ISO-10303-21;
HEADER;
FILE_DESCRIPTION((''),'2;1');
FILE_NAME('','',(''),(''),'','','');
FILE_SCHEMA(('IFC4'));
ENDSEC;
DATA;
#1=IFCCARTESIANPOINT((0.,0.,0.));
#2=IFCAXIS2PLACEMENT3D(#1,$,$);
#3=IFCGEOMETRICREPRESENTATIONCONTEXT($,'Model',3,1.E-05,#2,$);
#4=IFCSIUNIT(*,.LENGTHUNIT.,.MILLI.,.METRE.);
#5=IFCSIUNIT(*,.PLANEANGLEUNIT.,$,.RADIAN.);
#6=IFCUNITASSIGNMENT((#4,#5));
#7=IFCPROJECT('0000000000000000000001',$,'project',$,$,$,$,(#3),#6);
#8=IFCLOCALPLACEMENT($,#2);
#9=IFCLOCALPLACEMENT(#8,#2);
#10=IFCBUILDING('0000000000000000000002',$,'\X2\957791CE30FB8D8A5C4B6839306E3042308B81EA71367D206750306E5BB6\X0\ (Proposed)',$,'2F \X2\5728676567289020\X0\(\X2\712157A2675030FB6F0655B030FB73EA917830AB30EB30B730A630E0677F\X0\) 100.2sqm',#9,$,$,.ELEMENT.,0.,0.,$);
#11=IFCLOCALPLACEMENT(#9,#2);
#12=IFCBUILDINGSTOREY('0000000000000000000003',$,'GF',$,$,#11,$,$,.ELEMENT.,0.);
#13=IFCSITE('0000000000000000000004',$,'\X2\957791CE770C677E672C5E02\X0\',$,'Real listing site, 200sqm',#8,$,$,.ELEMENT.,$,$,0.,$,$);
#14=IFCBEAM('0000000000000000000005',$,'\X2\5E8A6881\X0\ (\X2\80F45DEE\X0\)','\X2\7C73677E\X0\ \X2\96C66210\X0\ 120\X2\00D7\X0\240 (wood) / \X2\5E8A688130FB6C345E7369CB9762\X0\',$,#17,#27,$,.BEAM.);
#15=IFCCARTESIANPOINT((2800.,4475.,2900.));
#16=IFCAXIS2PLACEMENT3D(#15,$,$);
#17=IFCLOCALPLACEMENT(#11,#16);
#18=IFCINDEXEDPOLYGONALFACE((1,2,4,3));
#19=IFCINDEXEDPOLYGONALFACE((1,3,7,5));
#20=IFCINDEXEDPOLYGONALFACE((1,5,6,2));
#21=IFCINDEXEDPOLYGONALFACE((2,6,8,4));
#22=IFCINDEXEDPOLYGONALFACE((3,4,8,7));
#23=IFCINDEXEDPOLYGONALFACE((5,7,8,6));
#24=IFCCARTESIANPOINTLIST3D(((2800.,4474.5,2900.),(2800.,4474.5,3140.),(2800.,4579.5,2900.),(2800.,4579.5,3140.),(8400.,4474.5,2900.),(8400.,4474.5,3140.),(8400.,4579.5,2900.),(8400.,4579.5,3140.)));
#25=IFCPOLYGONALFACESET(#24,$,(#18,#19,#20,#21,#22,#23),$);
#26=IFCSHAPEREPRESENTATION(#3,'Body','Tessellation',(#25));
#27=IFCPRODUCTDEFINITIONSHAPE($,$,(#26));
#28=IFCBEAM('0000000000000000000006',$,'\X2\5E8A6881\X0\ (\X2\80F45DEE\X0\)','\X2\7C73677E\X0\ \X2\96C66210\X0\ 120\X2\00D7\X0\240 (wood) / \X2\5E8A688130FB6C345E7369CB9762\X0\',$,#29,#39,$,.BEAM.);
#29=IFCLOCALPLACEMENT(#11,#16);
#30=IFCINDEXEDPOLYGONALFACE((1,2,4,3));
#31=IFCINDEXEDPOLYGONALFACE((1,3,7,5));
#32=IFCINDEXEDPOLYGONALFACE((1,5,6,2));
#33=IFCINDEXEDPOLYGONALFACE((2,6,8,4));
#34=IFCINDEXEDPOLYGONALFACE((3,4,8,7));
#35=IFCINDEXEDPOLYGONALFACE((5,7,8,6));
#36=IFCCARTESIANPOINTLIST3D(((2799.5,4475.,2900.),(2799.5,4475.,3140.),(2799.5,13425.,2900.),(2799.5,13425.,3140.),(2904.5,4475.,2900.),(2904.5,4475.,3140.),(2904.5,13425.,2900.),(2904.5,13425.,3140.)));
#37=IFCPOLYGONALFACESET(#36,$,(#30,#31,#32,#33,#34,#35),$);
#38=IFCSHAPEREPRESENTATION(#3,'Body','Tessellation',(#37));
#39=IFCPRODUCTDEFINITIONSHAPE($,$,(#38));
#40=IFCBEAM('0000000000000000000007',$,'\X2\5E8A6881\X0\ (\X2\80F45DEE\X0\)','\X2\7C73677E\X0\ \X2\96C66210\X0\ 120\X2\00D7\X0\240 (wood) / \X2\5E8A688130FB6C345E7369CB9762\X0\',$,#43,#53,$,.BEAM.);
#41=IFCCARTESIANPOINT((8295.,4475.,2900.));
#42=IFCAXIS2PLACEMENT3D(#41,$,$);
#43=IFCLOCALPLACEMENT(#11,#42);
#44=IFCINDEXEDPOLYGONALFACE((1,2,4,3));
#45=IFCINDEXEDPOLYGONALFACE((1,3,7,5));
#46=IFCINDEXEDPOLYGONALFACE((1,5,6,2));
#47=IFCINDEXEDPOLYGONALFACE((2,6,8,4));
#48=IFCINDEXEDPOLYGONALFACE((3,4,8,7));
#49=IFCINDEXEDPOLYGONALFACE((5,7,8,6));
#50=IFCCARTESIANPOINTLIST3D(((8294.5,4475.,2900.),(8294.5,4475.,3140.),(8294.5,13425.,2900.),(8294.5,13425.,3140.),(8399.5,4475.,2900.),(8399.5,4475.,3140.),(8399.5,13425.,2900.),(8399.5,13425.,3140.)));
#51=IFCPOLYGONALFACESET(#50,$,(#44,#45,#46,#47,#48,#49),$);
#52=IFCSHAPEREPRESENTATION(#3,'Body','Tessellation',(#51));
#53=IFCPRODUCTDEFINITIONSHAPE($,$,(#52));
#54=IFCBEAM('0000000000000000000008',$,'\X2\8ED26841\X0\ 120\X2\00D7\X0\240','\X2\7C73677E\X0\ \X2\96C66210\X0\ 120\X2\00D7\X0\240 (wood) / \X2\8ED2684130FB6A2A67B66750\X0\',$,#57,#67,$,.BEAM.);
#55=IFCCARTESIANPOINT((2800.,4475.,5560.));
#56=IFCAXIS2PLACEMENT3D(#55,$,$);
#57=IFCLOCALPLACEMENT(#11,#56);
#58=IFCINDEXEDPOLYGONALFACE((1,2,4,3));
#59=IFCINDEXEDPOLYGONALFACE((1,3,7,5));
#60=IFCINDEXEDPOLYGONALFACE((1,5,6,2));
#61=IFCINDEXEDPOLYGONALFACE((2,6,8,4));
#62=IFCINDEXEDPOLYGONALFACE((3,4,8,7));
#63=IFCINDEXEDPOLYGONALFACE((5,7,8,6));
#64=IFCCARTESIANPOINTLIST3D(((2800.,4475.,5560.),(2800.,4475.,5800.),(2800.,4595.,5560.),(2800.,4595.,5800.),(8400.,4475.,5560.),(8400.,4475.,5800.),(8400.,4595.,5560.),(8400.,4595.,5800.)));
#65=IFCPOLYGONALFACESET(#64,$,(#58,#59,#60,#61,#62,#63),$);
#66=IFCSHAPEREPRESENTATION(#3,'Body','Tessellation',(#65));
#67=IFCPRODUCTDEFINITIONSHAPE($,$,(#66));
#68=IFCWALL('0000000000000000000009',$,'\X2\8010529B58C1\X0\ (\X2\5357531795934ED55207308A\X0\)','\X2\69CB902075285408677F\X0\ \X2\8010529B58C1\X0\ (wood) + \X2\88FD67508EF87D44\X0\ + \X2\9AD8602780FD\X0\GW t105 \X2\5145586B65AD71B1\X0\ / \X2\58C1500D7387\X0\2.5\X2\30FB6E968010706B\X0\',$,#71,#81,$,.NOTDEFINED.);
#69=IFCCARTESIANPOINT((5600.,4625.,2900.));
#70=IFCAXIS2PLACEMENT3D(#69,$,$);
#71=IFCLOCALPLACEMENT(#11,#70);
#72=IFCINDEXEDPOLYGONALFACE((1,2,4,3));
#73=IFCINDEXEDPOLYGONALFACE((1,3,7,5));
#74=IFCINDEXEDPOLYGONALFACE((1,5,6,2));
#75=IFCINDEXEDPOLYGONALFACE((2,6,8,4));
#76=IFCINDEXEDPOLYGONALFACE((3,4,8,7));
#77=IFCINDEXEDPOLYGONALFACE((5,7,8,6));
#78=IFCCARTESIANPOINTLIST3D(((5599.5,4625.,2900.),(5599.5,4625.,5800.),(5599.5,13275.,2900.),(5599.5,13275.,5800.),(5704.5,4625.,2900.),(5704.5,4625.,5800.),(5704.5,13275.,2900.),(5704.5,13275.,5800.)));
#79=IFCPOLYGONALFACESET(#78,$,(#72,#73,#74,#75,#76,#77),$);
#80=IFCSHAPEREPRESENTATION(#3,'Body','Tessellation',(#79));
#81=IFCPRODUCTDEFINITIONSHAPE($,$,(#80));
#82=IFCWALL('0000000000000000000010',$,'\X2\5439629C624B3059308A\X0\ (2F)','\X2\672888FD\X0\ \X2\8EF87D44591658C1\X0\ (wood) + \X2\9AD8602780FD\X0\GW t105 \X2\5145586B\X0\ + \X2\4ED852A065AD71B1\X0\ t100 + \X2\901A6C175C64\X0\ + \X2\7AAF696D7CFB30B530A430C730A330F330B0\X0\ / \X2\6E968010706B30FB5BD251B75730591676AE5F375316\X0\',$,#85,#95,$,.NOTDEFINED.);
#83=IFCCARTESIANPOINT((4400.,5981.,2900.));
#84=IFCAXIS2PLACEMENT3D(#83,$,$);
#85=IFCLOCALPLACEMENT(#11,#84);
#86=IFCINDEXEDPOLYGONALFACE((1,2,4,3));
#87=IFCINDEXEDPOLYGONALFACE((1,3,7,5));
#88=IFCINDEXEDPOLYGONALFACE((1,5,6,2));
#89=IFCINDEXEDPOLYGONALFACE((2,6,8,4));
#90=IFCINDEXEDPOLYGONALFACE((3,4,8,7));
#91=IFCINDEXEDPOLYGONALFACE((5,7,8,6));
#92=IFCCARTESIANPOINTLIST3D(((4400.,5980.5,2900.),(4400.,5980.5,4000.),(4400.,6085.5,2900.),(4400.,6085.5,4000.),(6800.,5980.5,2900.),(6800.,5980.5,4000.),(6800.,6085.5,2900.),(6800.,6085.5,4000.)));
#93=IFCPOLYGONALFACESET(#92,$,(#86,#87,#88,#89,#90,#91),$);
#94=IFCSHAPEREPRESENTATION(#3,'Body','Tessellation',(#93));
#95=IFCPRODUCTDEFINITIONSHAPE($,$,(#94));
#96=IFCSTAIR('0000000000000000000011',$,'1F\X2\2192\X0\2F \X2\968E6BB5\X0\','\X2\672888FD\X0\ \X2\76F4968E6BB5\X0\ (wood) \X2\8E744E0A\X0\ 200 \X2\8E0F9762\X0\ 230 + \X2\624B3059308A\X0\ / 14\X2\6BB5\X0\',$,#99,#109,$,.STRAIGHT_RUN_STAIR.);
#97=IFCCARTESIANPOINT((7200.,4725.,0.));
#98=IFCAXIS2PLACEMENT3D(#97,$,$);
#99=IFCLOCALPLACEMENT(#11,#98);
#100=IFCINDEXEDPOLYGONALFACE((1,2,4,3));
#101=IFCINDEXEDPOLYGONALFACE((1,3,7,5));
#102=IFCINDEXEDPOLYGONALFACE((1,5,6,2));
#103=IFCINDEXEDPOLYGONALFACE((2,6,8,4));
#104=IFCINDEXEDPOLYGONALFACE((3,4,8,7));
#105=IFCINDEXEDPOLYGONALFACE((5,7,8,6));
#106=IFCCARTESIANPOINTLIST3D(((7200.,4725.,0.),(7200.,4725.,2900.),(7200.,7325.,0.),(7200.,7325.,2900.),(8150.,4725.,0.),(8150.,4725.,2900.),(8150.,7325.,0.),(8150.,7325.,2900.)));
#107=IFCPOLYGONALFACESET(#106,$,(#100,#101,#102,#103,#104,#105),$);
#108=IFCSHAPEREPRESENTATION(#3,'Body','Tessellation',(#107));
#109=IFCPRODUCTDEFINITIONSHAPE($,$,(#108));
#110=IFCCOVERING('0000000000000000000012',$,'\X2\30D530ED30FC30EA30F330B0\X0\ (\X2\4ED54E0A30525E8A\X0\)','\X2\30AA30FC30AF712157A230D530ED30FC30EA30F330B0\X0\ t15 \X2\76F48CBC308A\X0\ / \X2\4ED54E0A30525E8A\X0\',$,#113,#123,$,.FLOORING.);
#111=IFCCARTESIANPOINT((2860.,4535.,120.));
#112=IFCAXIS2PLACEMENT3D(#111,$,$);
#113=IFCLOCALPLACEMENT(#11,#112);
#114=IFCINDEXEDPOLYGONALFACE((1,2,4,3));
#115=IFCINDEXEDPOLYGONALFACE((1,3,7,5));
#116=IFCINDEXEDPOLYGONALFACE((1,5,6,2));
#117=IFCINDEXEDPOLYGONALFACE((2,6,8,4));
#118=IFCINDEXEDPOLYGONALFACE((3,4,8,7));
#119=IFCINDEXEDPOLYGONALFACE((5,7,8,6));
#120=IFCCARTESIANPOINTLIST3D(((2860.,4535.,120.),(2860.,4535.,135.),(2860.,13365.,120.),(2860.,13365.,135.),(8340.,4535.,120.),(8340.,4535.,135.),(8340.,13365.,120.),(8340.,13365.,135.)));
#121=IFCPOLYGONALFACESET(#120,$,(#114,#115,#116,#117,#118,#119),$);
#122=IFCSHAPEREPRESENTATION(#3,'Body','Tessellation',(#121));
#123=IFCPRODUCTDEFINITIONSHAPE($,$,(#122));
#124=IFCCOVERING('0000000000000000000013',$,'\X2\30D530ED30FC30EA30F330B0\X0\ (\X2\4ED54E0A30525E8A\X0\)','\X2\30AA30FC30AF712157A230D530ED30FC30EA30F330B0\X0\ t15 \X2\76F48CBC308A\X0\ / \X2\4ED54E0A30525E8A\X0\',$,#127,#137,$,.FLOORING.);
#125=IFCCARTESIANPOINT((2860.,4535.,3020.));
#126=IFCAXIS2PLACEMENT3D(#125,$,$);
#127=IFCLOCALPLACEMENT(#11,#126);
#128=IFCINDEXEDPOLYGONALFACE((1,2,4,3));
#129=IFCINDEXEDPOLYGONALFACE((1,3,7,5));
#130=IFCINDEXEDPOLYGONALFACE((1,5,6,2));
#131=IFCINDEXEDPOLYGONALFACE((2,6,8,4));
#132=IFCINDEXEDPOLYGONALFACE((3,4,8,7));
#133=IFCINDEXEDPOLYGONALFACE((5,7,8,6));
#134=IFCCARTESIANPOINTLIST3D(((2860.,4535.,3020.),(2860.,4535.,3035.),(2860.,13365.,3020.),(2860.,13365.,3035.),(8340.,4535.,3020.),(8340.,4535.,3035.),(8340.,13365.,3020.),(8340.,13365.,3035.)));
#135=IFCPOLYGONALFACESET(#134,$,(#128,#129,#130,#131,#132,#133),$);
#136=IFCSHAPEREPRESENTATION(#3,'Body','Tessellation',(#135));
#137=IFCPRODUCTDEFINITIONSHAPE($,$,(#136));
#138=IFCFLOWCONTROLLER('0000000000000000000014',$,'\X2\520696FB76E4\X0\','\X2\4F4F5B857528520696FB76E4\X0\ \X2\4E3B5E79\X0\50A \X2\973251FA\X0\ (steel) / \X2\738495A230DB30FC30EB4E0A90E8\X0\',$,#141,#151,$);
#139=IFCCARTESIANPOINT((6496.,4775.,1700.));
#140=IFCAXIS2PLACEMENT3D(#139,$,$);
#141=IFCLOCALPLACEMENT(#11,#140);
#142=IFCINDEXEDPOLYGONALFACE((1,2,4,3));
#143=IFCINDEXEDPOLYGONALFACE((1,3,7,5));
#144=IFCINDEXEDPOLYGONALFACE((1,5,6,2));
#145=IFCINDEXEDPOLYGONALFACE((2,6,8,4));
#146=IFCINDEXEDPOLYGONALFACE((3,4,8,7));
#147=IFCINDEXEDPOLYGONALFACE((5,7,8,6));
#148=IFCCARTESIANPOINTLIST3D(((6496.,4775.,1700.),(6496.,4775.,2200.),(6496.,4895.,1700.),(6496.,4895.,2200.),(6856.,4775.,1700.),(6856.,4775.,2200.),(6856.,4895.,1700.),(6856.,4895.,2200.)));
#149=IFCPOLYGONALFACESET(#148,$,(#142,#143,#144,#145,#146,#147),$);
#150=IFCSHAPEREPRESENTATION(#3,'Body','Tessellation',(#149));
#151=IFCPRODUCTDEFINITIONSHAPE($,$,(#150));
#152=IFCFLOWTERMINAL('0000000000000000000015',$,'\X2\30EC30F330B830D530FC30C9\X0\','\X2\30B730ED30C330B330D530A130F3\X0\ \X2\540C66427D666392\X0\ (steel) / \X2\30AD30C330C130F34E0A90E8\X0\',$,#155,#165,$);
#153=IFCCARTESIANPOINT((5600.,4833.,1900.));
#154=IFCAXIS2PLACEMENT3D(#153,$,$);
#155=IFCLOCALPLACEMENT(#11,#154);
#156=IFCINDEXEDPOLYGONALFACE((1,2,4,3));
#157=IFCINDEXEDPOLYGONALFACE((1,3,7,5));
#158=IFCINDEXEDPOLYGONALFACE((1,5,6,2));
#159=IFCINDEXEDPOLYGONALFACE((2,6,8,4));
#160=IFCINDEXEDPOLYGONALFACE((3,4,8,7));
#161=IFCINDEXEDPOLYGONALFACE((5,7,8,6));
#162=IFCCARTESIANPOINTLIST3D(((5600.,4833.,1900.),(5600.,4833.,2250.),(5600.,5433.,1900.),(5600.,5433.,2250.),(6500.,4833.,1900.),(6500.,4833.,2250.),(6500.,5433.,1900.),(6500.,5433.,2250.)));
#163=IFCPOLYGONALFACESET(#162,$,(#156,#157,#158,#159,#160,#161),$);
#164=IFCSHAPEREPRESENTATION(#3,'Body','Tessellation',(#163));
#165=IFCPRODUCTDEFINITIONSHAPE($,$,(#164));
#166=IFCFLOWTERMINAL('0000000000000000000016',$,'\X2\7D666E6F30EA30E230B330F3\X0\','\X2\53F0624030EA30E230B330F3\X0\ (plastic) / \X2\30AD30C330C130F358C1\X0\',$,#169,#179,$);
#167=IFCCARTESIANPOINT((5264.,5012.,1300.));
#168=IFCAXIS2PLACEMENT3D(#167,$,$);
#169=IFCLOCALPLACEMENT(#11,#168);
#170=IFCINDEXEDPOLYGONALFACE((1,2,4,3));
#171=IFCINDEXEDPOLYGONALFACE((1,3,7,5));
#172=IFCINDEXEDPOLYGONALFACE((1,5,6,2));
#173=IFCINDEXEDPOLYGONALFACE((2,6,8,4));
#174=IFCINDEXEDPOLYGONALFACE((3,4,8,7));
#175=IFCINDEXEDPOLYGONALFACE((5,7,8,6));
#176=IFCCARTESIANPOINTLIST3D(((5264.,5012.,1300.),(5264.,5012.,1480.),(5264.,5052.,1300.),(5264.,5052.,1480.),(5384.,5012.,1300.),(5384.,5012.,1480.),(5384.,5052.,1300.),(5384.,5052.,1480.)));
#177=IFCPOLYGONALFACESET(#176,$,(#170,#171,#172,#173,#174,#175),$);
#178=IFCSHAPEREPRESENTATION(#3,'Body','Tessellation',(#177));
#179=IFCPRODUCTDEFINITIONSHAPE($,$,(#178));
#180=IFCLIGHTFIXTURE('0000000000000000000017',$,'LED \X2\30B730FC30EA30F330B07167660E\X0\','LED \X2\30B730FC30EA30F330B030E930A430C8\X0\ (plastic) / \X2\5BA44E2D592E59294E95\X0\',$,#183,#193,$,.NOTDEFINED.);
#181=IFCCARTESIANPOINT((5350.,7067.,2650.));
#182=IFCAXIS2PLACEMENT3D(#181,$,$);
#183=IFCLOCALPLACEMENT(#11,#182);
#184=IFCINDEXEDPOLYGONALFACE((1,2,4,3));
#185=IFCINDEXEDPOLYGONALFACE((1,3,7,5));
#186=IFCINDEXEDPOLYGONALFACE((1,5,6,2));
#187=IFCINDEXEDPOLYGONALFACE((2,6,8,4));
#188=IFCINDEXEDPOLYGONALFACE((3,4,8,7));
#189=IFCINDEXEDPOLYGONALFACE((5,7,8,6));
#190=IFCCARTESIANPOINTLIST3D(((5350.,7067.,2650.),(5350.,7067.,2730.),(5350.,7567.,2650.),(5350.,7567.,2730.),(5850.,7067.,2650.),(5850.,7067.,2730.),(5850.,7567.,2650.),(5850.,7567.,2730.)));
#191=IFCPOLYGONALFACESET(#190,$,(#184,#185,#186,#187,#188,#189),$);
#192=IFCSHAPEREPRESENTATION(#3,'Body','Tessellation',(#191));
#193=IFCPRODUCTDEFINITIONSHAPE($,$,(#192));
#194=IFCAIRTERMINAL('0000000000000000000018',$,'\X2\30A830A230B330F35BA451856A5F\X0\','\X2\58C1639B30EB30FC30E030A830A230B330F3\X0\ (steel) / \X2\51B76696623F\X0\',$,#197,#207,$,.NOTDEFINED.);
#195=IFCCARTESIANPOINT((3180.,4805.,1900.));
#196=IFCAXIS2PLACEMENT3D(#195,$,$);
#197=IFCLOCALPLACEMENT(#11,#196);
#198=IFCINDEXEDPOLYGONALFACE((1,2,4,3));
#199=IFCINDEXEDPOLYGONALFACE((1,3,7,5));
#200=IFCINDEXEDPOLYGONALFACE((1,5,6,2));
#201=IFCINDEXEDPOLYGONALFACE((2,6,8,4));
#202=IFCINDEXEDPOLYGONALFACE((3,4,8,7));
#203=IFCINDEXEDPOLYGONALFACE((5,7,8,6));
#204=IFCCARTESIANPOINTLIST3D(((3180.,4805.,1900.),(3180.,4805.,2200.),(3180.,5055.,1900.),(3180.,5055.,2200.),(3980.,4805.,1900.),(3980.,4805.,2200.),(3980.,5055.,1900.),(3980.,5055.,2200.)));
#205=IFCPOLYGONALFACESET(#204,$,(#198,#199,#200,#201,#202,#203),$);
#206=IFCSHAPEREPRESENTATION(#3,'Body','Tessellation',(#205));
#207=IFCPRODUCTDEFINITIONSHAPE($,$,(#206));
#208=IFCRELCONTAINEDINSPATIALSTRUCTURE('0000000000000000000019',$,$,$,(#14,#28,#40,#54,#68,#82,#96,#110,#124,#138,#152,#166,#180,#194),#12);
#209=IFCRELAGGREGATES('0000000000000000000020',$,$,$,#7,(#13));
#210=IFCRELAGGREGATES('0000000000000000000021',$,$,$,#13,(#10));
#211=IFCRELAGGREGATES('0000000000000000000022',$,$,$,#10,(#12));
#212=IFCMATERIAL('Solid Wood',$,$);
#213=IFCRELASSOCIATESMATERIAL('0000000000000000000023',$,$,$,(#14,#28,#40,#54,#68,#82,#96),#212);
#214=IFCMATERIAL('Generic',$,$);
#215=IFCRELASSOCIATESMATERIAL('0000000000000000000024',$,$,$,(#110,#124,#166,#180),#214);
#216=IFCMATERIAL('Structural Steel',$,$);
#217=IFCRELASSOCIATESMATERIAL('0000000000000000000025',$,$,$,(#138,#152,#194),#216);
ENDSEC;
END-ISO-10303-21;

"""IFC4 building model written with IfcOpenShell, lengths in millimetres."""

from ifc_helpers import new_model, si_unit, frame, frame_2d, origin, place, context, project, spatial, rectangle, extrude, material, element, save


model = new_model("IFC4")

# Units and contexts
model_context = context("Model", 3, precision=1e-05, world=origin())
ifc_project = project(units=[si_unit("LENGTHUNIT", "METRE", prefix="MILLI"), si_unit("PLANEANGLEUNIT", "RADIAN")], contexts=[model_context])

# Site, building, storey
site_placement = place(None, origin())
site = spatial("IfcSite", under=ifc_project, at=site_placement, Name="長野県松本市", ObjectType="Real listing site, 200sqm", CompositionType="ELEMENT", RefElevation=0.0)
building_placement = place(site_placement, origin())
building = spatial("IfcBuilding", under=site, at=building_placement, Name="長野・越屋根のある自然素材の家 (Proposed)", ObjectType="2F 在来木造(無垢材・漆喰・珪酸カルシウム板) 100.2sqm", CompositionType="ELEMENT", ElevationOfRefHeight=0.0, ElevationOfTerrain=0.0)
storey_placement = place(building_placement, origin())
storey = spatial("IfcBuildingStorey", under=building, at=storey_placement, Name="GF", CompositionType="ELEMENT", Elevation=0.0)

# Shared definitions
ifc_material_1 = material(Name="Solid Wood")

# Beams
beam_1_placement = place(storey_placement, frame((2800.0, 4475.0, 2900.0)))
element("IfcBeam", 1, at=beam_1_placement, inside=storey, material=ifc_material_1, Name="床梁 (胴差)", Description="米松 集成 120×240 (wood) / 床梁・水平構面", PredefinedType="BEAM", context=model_context, shape_type="SweptSolid", body=[
    extrude(rectangle(XDim=5600.0, YDim=105.0, at=frame_2d((2800.0, 52.0))), frame((2800.0, 4475.0, 2900.0)), (0.0, 0.0, 1.0), 240.0),
])
beam_2_placement = place(storey_placement, frame((2800.0, 4475.0, 2900.0)))
element("IfcBeam", 2, at=beam_2_placement, inside=storey, material=ifc_material_1, Name="床梁 (胴差)", Description="米松 集成 120×240 (wood) / 床梁・水平構面", PredefinedType="BEAM", context=model_context, shape_type="SweptSolid", body=[
    extrude(rectangle(XDim=105.0, YDim=8950.0, at=frame_2d((52.0, 4475.0))), frame((2800.0, 4475.0, 2900.0)), (0.0, 0.0, 1.0), 240.0),
])
beam_3_placement = place(storey_placement, frame((8295.0, 4475.0, 2900.0)))
element("IfcBeam", 3, at=beam_3_placement, inside=storey, material=ifc_material_1, Name="床梁 (胴差)", Description="米松 集成 120×240 (wood) / 床梁・水平構面", PredefinedType="BEAM", context=model_context, shape_type="SweptSolid", body=[
    extrude(rectangle(XDim=105.0, YDim=8950.0, at=frame_2d((52.0, 4475.0))), frame((8295.0, 4475.0, 2900.0)), (0.0, 0.0, 1.0), 240.0),
])
beam_4_placement = place(storey_placement, frame((2800.0, 4475.0, 5560.0)))
element("IfcBeam", 4, at=beam_4_placement, inside=storey, material=ifc_material_1, Name="軒桁 120×240", Description="米松 集成 120×240 (wood) / 軒桁・横架材", PredefinedType="BEAM", context=model_context, shape_type="SweptSolid", body=[
    extrude(rectangle(XDim=5600.0, YDim=120.0, at=frame_2d((2800.0, 60.0))), frame((2800.0, 4475.0, 5560.0)), (0.0, 0.0, 1.0), 240.0),
])

# Walls
wall_1_placement = place(storey_placement, frame((5600.0, 4625.0, 2900.0)))
element("IfcWall", 5, at=wall_1_placement, inside=storey, material=ifc_material_1, Name="耐力壁 (南北間仕切り)", Description="構造用合板 耐力壁 (wood) + 製材軸組 + 高性能GW t105 充填断熱 / 壁倍率2.5・準耐火", PredefinedType="NOTDEFINED", context=model_context, shape_type="SweptSolid", body=[
    extrude(rectangle(XDim=105.0, YDim=8650.0, at=frame_2d((52.0, 4325.0))), frame((5600.0, 4625.0, 2900.0)), (0.0, 0.0, 1.0), 2900.0),
])
wall_2_placement = place(storey_placement, frame((4400.0, 5981.0, 2900.0)))
element("IfcWall", 6, at=wall_2_placement, inside=storey, material=ifc_material_1, Name="吹抜手すり (2F)", Description="木製 軸組外壁 (wood) + 高性能GW t105 充填 + 付加断熱 t100 + 通気層 + 窯業系サイディング / 準耐火・寒冷地外皮強化", PredefinedType="NOTDEFINED", context=model_context, shape_type="SweptSolid", body=[
    extrude(rectangle(XDim=2400.0, YDim=105.0, at=frame_2d((1200.0, 52.0))), frame((4400.0, 5981.0, 2900.0)), (0.0, 0.0, 1.0), 1100.0),
])

# Stair
stair_placement = place(storey_placement, frame((7200.0, 4725.0, 0.0)))
element("IfcStair", 7, at=stair_placement, inside=storey, material=ifc_material_1, Name="1F→2F 階段", Description="木製 直階段 (wood) 蹴上 200 踏面 230 + 手すり / 14段", PredefinedType="STRAIGHT_RUN_STAIR", context=model_context, shape_type="SweptSolid", body=[
    extrude(rectangle(XDim=950.0, YDim=2600.0, at=frame_2d((475.0, 1300.0))), frame((7200.0, 4725.0, 0.0)), (0.0, 0.0, 1.0), 2900.0),
])

# Coverings
ifc_material_2 = material(Name="Generic")
covering_1_placement = place(storey_placement, frame((2860.0, 4535.0, 120.0)))
element("IfcCovering", 8, at=covering_1_placement, inside=storey, material=ifc_material_2, Name="フローリング (仕上げ床)", Description="オーク無垢フローリング t15 直貼り / 仕上げ床", PredefinedType="FLOORING", context=model_context, shape_type="SweptSolid", body=[
    extrude(rectangle(XDim=5480.0, YDim=8830.0, at=frame_2d((2740.0, 4415.0))), frame((2860.0, 4535.0, 120.0)), (0.0, 0.0, 1.0), 15.0),
])
covering_2_placement = place(storey_placement, frame((2860.0, 4535.0, 3020.0)))
element("IfcCovering", 9, at=covering_2_placement, inside=storey, material=ifc_material_2, Name="フローリング (仕上げ床)", Description="オーク無垢フローリング t15 直貼り / 仕上げ床", PredefinedType="FLOORING", context=model_context, shape_type="SweptSolid", body=[
    extrude(rectangle(XDim=5480.0, YDim=8830.0, at=frame_2d((2740.0, 4415.0))), frame((2860.0, 4535.0, 3020.0)), (0.0, 0.0, 1.0), 15.0),
])

# Flow controller
ifc_material_3 = material(Name="Structural Steel")
flow_controller_placement = place(storey_placement, frame((6496.0, 4775.0, 1700.0)))
element("IfcFlowController", 10, at=flow_controller_placement, inside=storey, material=ifc_material_3, Name="分電盤", Description="住宅用分電盤 主幹50A 露出 (steel) / 玄関ホール上部", context=model_context, shape_type="SweptSolid", body=[
    extrude(rectangle(XDim=360.0, YDim=120.0, at=frame_2d((180.0, 60.0))), frame((6496.0, 4775.0, 1700.0)), (0.0, 0.0, 1.0), 500.0),
])

# Flow terminals
flow_terminal_1_placement = place(storey_placement, frame((5600.0, 4833.0, 1900.0)))
element("IfcFlowTerminal", 11, at=flow_terminal_1_placement, inside=storey, material=ifc_material_3, Name="レンジフード", Description="シロッコファン 同時給排 (steel) / キッチン上部", context=model_context, shape_type="SweptSolid", body=[
    extrude(rectangle(XDim=900.0, YDim=600.0, at=frame_2d((450.0, 300.0))), frame((5600.0, 4833.0, 1900.0)), (0.0, 0.0, 1.0), 350.0),
])
flow_terminal_2_placement = place(storey_placement, frame((5264.0, 5012.0, 1300.0)))
element("IfcFlowTerminal", 12, at=flow_terminal_2_placement, inside=storey, material=ifc_material_2, Name="給湯リモコン", Description="台所リモコン (plastic) / キッチン壁", context=model_context, shape_type="SweptSolid", body=[
    extrude(rectangle(XDim=120.0, YDim=40.0, at=frame_2d((60.0, 20.0))), frame((5264.0, 5012.0, 1300.0)), (0.0, 0.0, 1.0), 180.0),
])

# Light fixture
light_fixture_1_placement = place(storey_placement, frame((5350.0, 7067.0, 2650.0)))
element("IfcLightFixture", 13, at=light_fixture_1_placement, inside=storey, material=ifc_material_2, Name="LED シーリング照明", Description="LED シーリングライト (plastic) / 室中央天井", PredefinedType="NOTDEFINED", context=model_context, shape_type="SweptSolid", body=[
    extrude(rectangle(XDim=500.0, YDim=500.0, at=frame_2d((250.0, 250.0))), frame((5350.0, 7067.0, 2650.0)), (0.0, 0.0, 1.0), 80.0),
])

# Air terminal
air_terminal_1_placement = place(storey_placement, frame((3180.0, 4805.0, 1900.0)))
element("IfcAirTerminal", 14, at=air_terminal_1_placement, inside=storey, material=ifc_material_3, Name="エアコン室内機", Description="壁掛ルームエアコン (steel) / 冷暖房", PredefinedType="NOTDEFINED", context=model_context, shape_type="SweptSolid", body=[
    extrude(rectangle(XDim=800.0, YDim=250.0, at=frame_2d((400.0, 125.0))), frame((3180.0, 4805.0, 1900.0)), (0.0, 0.0, 1.0), 300.0),
])

save(model, "model.ifc")
